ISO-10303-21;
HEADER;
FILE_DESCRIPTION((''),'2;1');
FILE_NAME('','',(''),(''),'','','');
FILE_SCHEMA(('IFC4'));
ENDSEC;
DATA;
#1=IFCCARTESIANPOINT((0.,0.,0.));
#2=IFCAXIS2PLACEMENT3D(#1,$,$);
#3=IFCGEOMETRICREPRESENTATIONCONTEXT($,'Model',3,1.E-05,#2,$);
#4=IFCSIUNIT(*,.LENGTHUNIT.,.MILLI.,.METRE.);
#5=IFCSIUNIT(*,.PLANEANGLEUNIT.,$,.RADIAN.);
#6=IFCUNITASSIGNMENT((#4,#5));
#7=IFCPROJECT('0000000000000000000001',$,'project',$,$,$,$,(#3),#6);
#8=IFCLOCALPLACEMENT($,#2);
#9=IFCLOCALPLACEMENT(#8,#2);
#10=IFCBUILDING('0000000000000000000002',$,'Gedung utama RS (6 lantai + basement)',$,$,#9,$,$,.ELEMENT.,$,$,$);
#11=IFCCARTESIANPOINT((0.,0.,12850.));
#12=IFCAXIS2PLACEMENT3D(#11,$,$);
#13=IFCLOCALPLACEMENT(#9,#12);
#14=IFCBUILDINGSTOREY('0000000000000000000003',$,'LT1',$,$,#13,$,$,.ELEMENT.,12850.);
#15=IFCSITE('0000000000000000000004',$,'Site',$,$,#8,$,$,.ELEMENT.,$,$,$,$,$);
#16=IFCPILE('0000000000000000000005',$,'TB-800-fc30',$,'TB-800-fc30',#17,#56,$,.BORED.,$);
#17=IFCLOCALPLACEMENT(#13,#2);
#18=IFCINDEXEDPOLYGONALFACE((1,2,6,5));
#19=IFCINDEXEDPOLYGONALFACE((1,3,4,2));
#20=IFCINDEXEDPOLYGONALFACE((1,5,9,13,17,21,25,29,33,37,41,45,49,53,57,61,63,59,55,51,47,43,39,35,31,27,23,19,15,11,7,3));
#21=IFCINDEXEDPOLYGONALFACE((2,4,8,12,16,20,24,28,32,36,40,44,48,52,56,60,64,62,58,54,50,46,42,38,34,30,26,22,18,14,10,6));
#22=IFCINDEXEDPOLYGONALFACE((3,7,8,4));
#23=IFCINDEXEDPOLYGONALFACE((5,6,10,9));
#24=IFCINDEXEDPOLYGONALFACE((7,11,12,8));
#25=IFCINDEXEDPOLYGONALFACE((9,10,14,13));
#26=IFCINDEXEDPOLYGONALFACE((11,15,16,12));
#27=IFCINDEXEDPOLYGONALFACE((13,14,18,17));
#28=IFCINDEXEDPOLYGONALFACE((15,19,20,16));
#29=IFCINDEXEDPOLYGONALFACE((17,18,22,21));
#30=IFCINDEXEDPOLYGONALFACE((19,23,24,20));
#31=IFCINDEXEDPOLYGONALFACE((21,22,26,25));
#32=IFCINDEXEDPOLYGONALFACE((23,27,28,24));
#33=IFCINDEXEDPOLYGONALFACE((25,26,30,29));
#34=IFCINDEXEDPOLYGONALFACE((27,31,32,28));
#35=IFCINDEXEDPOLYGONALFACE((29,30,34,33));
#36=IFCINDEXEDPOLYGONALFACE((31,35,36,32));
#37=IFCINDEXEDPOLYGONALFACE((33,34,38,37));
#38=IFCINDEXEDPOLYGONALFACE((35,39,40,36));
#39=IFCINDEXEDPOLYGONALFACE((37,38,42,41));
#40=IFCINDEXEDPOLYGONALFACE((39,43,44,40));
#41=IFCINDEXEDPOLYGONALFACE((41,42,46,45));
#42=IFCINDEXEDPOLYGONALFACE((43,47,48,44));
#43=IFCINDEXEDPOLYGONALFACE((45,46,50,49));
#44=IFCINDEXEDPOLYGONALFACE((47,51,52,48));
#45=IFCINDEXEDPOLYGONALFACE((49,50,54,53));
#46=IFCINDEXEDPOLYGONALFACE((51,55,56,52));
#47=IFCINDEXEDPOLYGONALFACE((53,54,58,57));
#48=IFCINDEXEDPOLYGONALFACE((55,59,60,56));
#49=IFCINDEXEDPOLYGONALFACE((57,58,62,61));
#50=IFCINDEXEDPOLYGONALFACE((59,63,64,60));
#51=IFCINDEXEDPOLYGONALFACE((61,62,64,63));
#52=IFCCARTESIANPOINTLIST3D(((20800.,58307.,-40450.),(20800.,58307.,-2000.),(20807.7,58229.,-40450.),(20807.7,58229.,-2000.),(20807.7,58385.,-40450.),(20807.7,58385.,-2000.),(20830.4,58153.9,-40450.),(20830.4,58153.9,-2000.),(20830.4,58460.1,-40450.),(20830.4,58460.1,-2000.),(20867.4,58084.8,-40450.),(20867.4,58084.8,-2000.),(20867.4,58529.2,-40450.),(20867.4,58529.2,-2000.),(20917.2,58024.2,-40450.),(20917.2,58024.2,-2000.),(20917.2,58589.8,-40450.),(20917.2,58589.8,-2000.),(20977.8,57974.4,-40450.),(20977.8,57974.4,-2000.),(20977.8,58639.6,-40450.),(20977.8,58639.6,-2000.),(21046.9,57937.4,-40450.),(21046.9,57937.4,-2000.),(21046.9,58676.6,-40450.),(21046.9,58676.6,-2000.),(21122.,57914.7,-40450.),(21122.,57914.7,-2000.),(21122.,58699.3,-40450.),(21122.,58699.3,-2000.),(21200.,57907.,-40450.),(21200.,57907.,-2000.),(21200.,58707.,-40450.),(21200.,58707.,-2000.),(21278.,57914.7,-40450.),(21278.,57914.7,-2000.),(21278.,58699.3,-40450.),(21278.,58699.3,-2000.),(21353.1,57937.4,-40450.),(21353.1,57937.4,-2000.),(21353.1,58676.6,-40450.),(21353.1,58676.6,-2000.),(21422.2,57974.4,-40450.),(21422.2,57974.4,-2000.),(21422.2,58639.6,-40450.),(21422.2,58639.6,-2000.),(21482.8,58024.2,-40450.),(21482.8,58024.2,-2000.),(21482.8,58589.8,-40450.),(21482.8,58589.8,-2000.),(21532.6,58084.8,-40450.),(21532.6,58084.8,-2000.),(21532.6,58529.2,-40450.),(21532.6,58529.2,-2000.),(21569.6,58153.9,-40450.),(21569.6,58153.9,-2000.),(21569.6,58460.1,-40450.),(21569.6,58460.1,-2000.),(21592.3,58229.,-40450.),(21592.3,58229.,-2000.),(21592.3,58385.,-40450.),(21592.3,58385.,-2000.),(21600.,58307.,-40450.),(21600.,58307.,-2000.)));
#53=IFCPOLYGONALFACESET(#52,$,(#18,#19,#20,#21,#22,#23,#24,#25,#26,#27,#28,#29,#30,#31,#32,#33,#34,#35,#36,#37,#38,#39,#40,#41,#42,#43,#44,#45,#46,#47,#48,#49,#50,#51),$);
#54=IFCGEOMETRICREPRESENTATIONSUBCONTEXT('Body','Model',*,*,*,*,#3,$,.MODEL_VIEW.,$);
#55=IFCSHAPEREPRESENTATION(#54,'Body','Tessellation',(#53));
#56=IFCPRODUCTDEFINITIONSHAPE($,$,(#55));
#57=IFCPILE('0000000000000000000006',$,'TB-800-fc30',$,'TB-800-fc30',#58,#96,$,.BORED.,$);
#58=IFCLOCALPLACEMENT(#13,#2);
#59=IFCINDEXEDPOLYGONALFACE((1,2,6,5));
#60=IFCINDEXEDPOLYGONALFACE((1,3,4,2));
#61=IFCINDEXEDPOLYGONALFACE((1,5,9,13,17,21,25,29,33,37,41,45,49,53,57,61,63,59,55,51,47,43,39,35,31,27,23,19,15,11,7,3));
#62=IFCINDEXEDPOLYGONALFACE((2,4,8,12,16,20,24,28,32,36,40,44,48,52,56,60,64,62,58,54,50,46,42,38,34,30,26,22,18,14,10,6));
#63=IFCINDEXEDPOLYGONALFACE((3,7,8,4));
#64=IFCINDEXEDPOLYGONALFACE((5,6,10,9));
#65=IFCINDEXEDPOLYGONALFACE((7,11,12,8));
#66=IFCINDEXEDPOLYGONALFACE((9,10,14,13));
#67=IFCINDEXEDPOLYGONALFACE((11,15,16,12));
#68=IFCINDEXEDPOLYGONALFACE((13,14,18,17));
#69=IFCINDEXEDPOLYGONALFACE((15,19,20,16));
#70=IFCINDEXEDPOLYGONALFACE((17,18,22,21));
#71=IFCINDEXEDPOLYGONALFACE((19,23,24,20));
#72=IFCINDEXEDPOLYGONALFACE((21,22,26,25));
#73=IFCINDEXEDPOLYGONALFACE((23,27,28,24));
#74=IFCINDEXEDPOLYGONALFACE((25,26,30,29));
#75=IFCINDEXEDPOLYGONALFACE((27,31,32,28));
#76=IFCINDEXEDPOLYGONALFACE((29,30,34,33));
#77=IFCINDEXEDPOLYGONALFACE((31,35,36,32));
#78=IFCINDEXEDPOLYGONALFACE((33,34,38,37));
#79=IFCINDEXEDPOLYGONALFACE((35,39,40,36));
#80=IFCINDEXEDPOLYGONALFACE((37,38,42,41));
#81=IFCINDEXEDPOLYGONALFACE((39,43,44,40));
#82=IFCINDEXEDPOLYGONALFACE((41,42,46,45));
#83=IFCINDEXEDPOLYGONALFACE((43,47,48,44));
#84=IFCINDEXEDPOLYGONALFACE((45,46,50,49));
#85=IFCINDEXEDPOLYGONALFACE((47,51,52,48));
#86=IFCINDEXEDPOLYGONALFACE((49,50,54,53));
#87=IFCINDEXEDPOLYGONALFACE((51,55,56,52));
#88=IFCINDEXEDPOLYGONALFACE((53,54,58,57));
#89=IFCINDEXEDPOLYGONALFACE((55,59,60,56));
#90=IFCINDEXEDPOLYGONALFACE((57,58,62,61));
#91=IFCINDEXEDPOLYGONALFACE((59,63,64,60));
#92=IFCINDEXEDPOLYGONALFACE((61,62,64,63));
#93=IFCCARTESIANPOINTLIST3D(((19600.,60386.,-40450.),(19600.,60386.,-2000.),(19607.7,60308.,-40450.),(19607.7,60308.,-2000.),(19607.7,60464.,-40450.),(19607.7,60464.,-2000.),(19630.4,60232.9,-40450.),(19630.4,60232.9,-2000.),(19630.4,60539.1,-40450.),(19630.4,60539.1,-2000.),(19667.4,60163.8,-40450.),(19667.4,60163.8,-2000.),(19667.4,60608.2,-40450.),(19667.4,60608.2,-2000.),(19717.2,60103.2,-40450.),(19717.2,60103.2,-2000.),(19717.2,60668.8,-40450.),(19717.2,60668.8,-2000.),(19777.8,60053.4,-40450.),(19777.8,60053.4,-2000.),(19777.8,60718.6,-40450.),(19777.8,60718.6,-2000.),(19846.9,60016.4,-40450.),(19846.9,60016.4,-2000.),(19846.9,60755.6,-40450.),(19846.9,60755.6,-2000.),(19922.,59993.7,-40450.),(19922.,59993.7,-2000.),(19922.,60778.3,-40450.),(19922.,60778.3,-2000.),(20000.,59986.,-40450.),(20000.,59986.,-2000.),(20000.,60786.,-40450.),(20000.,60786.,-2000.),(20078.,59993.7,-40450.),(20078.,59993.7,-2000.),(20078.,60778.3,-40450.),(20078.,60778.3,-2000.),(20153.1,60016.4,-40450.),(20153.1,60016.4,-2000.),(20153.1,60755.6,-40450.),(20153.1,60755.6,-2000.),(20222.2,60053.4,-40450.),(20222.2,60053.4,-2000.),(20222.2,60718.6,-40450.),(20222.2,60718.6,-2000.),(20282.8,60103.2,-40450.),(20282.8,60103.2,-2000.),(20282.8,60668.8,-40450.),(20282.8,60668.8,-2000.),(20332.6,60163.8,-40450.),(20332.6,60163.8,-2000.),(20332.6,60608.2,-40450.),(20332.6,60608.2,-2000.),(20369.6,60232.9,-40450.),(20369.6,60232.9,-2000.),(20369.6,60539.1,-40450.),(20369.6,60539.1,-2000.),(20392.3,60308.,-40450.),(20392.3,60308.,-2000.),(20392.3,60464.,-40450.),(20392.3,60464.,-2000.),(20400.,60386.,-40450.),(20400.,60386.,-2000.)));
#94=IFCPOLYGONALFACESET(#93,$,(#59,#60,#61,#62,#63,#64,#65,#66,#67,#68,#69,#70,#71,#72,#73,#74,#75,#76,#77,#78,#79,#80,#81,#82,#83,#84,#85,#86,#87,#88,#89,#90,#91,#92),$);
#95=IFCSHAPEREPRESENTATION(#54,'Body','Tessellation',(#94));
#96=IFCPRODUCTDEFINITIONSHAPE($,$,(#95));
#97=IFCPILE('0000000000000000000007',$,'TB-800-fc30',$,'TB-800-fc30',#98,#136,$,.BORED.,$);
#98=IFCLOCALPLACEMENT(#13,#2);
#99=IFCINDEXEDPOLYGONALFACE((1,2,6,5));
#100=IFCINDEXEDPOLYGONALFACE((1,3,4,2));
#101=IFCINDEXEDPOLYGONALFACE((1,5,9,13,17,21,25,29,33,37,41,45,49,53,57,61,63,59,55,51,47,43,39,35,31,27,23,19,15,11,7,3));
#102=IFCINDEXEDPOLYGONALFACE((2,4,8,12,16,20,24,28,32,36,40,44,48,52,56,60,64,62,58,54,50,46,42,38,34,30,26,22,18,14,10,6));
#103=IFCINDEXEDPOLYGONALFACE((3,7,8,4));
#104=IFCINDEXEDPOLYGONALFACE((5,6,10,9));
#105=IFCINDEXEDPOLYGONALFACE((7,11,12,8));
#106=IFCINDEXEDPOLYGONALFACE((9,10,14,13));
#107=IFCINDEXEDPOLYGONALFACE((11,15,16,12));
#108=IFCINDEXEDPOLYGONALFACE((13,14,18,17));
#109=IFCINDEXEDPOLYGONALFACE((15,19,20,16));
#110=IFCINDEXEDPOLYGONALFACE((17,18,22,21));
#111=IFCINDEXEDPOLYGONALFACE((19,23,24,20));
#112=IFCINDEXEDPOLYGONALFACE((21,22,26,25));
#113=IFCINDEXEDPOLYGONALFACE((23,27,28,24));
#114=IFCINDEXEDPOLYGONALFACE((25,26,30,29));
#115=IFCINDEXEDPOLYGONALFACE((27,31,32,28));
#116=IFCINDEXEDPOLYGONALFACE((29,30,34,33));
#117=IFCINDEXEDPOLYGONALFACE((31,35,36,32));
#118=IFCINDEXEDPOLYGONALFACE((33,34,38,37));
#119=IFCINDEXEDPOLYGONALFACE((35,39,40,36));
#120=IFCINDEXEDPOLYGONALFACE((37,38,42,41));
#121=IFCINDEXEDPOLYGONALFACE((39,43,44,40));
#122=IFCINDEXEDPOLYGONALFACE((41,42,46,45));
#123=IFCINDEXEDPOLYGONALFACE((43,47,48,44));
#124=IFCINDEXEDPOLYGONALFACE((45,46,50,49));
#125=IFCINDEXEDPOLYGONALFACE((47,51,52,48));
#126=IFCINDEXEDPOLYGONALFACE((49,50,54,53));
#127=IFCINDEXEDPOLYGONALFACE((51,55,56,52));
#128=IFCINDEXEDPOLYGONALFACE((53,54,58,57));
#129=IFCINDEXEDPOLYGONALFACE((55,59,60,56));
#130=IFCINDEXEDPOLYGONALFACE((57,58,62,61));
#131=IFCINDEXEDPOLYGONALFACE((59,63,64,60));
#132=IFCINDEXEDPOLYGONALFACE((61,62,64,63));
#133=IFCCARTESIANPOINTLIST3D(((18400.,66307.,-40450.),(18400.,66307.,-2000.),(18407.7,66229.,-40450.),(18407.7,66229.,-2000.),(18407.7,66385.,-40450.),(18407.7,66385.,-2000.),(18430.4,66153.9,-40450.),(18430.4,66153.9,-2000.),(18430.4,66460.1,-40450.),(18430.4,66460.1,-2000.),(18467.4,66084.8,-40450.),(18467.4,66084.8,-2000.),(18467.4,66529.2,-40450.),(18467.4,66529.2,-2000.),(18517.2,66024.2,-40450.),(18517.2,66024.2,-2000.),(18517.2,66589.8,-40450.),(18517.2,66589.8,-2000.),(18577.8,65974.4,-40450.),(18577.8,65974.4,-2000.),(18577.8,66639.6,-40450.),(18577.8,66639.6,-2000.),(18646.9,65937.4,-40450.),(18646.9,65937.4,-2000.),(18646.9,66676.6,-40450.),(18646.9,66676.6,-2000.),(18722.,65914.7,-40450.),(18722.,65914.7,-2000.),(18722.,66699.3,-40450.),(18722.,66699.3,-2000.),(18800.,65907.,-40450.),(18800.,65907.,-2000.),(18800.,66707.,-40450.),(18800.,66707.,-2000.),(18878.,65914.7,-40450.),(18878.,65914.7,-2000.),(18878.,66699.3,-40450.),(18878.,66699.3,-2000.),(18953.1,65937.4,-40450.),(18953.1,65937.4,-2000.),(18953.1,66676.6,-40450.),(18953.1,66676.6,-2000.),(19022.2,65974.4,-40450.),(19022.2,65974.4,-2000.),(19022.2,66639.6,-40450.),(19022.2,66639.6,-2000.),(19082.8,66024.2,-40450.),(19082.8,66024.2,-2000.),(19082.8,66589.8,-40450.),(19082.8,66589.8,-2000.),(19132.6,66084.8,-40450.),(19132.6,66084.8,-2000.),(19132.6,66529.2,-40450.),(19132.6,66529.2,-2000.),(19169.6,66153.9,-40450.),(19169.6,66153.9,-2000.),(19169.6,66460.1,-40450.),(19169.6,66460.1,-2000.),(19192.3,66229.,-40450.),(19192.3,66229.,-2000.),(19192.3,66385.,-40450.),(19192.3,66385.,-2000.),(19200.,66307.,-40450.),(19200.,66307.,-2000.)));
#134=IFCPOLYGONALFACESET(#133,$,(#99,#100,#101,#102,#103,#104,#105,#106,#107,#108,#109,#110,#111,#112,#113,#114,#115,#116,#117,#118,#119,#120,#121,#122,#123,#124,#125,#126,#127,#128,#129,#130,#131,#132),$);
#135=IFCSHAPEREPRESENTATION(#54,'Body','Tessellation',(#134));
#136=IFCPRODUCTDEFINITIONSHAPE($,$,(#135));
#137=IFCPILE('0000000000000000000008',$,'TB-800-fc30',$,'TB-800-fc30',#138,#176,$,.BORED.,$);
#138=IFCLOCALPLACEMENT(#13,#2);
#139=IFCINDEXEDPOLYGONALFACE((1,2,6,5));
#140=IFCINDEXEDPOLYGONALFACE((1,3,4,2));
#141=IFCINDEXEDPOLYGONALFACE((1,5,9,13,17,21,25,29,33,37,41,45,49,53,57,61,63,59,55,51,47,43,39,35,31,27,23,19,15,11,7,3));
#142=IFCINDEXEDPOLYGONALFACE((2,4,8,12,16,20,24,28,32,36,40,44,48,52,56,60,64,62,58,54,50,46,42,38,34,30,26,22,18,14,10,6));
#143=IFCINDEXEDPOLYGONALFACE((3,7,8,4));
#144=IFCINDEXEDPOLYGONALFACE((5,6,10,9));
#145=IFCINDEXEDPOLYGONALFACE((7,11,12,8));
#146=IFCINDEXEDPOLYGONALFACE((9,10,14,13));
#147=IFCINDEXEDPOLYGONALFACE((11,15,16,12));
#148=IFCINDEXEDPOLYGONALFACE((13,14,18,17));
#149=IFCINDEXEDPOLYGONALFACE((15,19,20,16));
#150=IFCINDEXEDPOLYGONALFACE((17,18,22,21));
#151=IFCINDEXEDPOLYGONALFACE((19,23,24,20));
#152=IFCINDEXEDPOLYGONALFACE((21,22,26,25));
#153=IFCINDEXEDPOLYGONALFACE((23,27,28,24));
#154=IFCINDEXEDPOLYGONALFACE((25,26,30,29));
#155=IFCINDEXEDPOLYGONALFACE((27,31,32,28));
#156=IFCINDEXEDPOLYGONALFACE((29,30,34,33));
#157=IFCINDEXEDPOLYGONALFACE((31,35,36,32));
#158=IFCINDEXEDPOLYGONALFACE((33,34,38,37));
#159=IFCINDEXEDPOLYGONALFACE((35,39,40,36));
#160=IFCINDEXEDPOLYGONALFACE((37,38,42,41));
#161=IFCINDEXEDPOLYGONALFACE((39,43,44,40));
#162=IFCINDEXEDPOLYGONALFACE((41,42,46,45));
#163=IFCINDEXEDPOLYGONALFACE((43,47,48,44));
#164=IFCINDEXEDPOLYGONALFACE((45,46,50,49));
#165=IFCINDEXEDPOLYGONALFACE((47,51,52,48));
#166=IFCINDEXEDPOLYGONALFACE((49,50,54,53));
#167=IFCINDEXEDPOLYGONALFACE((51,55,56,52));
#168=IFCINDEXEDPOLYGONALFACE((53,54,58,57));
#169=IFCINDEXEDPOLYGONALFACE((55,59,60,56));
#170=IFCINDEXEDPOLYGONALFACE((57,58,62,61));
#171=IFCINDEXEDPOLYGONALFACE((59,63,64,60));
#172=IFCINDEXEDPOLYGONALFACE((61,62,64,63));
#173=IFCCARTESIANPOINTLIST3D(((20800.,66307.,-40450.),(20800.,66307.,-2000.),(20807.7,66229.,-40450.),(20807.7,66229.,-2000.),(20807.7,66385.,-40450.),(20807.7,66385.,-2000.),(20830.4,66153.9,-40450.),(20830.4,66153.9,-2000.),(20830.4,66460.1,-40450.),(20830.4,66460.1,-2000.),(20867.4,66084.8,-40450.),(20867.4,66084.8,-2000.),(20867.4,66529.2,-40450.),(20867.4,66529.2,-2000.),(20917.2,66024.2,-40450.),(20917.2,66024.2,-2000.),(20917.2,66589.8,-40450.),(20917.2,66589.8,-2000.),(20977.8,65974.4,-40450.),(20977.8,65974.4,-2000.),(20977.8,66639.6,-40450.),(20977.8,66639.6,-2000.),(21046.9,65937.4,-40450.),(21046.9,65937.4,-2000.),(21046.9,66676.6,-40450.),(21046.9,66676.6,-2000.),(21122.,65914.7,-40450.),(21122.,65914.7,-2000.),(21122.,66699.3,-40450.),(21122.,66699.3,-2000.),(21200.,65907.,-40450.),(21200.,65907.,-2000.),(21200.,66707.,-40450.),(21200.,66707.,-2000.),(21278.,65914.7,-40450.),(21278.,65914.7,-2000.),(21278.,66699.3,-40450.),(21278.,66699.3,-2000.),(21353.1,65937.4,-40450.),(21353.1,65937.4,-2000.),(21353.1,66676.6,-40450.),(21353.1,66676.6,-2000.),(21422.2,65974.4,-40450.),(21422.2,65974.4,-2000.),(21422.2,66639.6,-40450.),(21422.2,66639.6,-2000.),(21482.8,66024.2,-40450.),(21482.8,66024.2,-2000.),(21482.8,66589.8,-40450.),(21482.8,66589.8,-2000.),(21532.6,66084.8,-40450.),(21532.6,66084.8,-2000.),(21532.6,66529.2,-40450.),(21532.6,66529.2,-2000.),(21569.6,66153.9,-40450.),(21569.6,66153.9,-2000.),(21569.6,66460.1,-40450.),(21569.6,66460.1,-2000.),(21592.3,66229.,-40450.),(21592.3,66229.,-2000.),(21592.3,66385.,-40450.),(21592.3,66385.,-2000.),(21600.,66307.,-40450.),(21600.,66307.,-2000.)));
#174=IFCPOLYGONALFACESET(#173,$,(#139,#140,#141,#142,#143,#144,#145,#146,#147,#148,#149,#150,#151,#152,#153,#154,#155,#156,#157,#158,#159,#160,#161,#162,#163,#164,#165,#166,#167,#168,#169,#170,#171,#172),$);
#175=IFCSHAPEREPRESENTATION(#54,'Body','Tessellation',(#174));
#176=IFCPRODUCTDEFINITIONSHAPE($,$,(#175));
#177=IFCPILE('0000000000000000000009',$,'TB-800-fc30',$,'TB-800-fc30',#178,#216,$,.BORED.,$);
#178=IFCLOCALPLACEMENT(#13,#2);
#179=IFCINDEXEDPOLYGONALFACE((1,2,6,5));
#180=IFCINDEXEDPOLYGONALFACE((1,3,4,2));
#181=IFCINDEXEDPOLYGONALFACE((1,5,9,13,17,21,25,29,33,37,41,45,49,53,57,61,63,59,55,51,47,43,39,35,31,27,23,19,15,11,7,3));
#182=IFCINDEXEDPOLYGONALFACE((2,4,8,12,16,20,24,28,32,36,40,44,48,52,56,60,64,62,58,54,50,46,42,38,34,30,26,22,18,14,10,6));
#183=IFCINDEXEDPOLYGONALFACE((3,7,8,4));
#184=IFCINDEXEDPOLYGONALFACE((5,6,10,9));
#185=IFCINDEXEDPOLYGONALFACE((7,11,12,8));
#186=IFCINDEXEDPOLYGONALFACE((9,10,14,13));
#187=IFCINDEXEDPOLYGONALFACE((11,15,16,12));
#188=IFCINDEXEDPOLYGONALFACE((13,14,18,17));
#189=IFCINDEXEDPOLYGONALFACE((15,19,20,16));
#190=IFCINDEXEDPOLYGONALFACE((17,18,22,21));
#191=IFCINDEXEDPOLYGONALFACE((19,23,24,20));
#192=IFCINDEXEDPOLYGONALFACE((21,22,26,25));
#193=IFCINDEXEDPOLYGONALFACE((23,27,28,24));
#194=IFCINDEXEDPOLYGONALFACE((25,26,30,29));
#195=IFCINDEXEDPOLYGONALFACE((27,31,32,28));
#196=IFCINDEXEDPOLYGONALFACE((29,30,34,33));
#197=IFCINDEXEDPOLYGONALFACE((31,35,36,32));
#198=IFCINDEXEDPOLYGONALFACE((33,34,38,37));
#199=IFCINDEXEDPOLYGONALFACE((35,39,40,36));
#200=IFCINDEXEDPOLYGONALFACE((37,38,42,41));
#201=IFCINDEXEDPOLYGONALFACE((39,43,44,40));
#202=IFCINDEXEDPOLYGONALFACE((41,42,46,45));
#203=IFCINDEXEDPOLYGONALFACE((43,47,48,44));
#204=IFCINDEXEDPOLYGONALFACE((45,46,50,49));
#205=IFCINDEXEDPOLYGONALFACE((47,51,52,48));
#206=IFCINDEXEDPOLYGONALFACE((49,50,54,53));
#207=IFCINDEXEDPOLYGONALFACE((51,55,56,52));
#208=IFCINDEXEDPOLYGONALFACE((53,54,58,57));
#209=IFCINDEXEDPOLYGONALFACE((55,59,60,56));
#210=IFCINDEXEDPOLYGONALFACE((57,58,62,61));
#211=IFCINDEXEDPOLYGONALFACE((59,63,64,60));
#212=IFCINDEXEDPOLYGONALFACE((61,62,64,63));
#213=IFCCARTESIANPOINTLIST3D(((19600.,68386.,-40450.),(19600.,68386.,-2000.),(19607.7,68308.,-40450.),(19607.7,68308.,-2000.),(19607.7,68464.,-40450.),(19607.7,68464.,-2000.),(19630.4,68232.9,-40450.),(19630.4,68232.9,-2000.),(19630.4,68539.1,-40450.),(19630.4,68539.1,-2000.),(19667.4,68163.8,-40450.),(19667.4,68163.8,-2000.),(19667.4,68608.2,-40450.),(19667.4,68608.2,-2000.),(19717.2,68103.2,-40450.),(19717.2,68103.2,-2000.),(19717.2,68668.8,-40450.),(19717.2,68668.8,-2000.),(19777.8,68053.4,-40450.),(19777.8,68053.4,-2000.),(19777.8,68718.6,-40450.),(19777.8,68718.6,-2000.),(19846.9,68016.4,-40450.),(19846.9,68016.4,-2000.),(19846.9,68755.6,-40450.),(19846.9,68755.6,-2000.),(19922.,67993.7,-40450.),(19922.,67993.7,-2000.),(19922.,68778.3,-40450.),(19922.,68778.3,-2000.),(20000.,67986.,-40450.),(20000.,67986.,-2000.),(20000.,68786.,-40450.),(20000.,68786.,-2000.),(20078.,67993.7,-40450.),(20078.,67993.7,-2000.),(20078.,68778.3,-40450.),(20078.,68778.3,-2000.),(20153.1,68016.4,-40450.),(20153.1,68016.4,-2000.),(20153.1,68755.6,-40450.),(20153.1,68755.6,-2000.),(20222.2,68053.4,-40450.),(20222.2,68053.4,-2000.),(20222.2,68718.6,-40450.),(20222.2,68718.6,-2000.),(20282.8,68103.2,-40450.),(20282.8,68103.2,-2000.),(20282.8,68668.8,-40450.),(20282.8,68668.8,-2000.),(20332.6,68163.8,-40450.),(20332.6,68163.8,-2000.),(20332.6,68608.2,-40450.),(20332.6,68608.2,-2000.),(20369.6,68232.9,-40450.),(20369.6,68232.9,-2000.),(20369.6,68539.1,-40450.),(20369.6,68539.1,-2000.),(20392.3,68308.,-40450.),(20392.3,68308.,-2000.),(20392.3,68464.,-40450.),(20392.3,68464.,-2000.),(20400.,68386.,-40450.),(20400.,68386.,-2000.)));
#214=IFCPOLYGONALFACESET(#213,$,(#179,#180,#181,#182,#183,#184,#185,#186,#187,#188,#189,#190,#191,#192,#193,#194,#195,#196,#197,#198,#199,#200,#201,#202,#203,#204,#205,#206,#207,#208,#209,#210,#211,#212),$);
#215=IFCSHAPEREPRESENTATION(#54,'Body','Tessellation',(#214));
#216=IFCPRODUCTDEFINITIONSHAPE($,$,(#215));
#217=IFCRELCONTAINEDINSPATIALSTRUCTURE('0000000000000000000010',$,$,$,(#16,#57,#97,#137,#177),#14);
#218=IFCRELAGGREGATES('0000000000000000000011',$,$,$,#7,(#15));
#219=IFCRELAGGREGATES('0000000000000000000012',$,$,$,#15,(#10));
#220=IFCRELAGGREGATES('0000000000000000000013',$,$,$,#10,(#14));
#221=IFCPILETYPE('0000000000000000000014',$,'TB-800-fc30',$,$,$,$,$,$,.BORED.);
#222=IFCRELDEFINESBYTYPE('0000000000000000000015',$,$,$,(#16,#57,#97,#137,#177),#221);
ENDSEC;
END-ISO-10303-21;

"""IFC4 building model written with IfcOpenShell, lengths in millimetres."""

from ifc_helpers import new_model, si_unit, frame, origin, origin_2d, place, context, subcontext, project, spatial, circle, extrude, material_profile, profile_set, profile_usage, type_object, element, save


model = new_model("IFC4")

# Units and contexts
model_context = context("Model", 3, precision=1e-05, world=origin())
body_context = subcontext(model_context, "Body", "Model", "MODEL_VIEW")
ifc_project = project(units=[si_unit("LENGTHUNIT", "METRE", prefix="MILLI"), si_unit("PLANEANGLEUNIT", "RADIAN")], contexts=[model_context])

# Site, building, storey
site_placement = place(None, origin())
site = spatial("IfcSite", under=ifc_project, at=site_placement, Name="Site", CompositionType="ELEMENT")
building_placement = place(site_placement, origin())
building = spatial("IfcBuilding", under=site, at=building_placement, Name="Gedung utama RS (6 lantai + basement)", CompositionType="ELEMENT")
storey_placement = place(building_placement, frame((0.0, 0.0, 12850.0)))
storey = spatial("IfcBuildingStorey", under=building, at=storey_placement, Name="LT1", CompositionType="ELEMENT", Elevation=12850.0)

# Piles
ifc_material_profile = material_profile(None, circle(Radius=400.0, at=origin_2d()), Name="TB-800-fc30")
ifc_profile_set = profile_set([ifc_material_profile], Name="TB-800-fc30")
ifc_profile_usage = profile_usage(ifc_profile_set, cardinal=5)
pile_type = type_object("IfcPileType", Name="TB-800-fc30", PredefinedType="BORED", material=ifc_profile_set)
for number, where, z_axis, x_axis, name in (
    (1, (21200.0, 58307.0, -40450.0), (0.0, 0.0, 1.0), (1.0, 0.0, 0.0), "TB-800-fc30"),
    (2, (20000.0, 60386.0, -40450.0), (0.0, 0.0, 1.0), (1.0, 0.0, 0.0), "TB-800-fc30"),
    (3, (18800.0, 66307.0, -40450.0), (0.0, 0.0, 1.0), (1.0, 0.0, 0.0), "TB-800-fc30"),
    (4, (21200.0, 66307.0, -40450.0), (0.0, 0.0, 1.0), (1.0, 0.0, 0.0), "TB-800-fc30"),
    (5, (20000.0, 68386.0, -40450.0), (0.0, 0.0, 1.0), (1.0, 0.0, 0.0), "TB-800-fc30"),
):
    element("IfcPile", number, at=place(storey_placement, frame(where, z_axis=z_axis, x_axis=x_axis)), inside=storey, type_object=pile_type, material=ifc_profile_usage, Name=name, ObjectType="TB-800-fc30", PredefinedType="BORED", context=body_context, shape_type="SweptSolid", body=[
        extrude(circle(Radius=400.0, at=origin_2d()), origin(), (0.0, 0.0, 1.0), 38450.0),
    ])

save(model, "model.ifc")
